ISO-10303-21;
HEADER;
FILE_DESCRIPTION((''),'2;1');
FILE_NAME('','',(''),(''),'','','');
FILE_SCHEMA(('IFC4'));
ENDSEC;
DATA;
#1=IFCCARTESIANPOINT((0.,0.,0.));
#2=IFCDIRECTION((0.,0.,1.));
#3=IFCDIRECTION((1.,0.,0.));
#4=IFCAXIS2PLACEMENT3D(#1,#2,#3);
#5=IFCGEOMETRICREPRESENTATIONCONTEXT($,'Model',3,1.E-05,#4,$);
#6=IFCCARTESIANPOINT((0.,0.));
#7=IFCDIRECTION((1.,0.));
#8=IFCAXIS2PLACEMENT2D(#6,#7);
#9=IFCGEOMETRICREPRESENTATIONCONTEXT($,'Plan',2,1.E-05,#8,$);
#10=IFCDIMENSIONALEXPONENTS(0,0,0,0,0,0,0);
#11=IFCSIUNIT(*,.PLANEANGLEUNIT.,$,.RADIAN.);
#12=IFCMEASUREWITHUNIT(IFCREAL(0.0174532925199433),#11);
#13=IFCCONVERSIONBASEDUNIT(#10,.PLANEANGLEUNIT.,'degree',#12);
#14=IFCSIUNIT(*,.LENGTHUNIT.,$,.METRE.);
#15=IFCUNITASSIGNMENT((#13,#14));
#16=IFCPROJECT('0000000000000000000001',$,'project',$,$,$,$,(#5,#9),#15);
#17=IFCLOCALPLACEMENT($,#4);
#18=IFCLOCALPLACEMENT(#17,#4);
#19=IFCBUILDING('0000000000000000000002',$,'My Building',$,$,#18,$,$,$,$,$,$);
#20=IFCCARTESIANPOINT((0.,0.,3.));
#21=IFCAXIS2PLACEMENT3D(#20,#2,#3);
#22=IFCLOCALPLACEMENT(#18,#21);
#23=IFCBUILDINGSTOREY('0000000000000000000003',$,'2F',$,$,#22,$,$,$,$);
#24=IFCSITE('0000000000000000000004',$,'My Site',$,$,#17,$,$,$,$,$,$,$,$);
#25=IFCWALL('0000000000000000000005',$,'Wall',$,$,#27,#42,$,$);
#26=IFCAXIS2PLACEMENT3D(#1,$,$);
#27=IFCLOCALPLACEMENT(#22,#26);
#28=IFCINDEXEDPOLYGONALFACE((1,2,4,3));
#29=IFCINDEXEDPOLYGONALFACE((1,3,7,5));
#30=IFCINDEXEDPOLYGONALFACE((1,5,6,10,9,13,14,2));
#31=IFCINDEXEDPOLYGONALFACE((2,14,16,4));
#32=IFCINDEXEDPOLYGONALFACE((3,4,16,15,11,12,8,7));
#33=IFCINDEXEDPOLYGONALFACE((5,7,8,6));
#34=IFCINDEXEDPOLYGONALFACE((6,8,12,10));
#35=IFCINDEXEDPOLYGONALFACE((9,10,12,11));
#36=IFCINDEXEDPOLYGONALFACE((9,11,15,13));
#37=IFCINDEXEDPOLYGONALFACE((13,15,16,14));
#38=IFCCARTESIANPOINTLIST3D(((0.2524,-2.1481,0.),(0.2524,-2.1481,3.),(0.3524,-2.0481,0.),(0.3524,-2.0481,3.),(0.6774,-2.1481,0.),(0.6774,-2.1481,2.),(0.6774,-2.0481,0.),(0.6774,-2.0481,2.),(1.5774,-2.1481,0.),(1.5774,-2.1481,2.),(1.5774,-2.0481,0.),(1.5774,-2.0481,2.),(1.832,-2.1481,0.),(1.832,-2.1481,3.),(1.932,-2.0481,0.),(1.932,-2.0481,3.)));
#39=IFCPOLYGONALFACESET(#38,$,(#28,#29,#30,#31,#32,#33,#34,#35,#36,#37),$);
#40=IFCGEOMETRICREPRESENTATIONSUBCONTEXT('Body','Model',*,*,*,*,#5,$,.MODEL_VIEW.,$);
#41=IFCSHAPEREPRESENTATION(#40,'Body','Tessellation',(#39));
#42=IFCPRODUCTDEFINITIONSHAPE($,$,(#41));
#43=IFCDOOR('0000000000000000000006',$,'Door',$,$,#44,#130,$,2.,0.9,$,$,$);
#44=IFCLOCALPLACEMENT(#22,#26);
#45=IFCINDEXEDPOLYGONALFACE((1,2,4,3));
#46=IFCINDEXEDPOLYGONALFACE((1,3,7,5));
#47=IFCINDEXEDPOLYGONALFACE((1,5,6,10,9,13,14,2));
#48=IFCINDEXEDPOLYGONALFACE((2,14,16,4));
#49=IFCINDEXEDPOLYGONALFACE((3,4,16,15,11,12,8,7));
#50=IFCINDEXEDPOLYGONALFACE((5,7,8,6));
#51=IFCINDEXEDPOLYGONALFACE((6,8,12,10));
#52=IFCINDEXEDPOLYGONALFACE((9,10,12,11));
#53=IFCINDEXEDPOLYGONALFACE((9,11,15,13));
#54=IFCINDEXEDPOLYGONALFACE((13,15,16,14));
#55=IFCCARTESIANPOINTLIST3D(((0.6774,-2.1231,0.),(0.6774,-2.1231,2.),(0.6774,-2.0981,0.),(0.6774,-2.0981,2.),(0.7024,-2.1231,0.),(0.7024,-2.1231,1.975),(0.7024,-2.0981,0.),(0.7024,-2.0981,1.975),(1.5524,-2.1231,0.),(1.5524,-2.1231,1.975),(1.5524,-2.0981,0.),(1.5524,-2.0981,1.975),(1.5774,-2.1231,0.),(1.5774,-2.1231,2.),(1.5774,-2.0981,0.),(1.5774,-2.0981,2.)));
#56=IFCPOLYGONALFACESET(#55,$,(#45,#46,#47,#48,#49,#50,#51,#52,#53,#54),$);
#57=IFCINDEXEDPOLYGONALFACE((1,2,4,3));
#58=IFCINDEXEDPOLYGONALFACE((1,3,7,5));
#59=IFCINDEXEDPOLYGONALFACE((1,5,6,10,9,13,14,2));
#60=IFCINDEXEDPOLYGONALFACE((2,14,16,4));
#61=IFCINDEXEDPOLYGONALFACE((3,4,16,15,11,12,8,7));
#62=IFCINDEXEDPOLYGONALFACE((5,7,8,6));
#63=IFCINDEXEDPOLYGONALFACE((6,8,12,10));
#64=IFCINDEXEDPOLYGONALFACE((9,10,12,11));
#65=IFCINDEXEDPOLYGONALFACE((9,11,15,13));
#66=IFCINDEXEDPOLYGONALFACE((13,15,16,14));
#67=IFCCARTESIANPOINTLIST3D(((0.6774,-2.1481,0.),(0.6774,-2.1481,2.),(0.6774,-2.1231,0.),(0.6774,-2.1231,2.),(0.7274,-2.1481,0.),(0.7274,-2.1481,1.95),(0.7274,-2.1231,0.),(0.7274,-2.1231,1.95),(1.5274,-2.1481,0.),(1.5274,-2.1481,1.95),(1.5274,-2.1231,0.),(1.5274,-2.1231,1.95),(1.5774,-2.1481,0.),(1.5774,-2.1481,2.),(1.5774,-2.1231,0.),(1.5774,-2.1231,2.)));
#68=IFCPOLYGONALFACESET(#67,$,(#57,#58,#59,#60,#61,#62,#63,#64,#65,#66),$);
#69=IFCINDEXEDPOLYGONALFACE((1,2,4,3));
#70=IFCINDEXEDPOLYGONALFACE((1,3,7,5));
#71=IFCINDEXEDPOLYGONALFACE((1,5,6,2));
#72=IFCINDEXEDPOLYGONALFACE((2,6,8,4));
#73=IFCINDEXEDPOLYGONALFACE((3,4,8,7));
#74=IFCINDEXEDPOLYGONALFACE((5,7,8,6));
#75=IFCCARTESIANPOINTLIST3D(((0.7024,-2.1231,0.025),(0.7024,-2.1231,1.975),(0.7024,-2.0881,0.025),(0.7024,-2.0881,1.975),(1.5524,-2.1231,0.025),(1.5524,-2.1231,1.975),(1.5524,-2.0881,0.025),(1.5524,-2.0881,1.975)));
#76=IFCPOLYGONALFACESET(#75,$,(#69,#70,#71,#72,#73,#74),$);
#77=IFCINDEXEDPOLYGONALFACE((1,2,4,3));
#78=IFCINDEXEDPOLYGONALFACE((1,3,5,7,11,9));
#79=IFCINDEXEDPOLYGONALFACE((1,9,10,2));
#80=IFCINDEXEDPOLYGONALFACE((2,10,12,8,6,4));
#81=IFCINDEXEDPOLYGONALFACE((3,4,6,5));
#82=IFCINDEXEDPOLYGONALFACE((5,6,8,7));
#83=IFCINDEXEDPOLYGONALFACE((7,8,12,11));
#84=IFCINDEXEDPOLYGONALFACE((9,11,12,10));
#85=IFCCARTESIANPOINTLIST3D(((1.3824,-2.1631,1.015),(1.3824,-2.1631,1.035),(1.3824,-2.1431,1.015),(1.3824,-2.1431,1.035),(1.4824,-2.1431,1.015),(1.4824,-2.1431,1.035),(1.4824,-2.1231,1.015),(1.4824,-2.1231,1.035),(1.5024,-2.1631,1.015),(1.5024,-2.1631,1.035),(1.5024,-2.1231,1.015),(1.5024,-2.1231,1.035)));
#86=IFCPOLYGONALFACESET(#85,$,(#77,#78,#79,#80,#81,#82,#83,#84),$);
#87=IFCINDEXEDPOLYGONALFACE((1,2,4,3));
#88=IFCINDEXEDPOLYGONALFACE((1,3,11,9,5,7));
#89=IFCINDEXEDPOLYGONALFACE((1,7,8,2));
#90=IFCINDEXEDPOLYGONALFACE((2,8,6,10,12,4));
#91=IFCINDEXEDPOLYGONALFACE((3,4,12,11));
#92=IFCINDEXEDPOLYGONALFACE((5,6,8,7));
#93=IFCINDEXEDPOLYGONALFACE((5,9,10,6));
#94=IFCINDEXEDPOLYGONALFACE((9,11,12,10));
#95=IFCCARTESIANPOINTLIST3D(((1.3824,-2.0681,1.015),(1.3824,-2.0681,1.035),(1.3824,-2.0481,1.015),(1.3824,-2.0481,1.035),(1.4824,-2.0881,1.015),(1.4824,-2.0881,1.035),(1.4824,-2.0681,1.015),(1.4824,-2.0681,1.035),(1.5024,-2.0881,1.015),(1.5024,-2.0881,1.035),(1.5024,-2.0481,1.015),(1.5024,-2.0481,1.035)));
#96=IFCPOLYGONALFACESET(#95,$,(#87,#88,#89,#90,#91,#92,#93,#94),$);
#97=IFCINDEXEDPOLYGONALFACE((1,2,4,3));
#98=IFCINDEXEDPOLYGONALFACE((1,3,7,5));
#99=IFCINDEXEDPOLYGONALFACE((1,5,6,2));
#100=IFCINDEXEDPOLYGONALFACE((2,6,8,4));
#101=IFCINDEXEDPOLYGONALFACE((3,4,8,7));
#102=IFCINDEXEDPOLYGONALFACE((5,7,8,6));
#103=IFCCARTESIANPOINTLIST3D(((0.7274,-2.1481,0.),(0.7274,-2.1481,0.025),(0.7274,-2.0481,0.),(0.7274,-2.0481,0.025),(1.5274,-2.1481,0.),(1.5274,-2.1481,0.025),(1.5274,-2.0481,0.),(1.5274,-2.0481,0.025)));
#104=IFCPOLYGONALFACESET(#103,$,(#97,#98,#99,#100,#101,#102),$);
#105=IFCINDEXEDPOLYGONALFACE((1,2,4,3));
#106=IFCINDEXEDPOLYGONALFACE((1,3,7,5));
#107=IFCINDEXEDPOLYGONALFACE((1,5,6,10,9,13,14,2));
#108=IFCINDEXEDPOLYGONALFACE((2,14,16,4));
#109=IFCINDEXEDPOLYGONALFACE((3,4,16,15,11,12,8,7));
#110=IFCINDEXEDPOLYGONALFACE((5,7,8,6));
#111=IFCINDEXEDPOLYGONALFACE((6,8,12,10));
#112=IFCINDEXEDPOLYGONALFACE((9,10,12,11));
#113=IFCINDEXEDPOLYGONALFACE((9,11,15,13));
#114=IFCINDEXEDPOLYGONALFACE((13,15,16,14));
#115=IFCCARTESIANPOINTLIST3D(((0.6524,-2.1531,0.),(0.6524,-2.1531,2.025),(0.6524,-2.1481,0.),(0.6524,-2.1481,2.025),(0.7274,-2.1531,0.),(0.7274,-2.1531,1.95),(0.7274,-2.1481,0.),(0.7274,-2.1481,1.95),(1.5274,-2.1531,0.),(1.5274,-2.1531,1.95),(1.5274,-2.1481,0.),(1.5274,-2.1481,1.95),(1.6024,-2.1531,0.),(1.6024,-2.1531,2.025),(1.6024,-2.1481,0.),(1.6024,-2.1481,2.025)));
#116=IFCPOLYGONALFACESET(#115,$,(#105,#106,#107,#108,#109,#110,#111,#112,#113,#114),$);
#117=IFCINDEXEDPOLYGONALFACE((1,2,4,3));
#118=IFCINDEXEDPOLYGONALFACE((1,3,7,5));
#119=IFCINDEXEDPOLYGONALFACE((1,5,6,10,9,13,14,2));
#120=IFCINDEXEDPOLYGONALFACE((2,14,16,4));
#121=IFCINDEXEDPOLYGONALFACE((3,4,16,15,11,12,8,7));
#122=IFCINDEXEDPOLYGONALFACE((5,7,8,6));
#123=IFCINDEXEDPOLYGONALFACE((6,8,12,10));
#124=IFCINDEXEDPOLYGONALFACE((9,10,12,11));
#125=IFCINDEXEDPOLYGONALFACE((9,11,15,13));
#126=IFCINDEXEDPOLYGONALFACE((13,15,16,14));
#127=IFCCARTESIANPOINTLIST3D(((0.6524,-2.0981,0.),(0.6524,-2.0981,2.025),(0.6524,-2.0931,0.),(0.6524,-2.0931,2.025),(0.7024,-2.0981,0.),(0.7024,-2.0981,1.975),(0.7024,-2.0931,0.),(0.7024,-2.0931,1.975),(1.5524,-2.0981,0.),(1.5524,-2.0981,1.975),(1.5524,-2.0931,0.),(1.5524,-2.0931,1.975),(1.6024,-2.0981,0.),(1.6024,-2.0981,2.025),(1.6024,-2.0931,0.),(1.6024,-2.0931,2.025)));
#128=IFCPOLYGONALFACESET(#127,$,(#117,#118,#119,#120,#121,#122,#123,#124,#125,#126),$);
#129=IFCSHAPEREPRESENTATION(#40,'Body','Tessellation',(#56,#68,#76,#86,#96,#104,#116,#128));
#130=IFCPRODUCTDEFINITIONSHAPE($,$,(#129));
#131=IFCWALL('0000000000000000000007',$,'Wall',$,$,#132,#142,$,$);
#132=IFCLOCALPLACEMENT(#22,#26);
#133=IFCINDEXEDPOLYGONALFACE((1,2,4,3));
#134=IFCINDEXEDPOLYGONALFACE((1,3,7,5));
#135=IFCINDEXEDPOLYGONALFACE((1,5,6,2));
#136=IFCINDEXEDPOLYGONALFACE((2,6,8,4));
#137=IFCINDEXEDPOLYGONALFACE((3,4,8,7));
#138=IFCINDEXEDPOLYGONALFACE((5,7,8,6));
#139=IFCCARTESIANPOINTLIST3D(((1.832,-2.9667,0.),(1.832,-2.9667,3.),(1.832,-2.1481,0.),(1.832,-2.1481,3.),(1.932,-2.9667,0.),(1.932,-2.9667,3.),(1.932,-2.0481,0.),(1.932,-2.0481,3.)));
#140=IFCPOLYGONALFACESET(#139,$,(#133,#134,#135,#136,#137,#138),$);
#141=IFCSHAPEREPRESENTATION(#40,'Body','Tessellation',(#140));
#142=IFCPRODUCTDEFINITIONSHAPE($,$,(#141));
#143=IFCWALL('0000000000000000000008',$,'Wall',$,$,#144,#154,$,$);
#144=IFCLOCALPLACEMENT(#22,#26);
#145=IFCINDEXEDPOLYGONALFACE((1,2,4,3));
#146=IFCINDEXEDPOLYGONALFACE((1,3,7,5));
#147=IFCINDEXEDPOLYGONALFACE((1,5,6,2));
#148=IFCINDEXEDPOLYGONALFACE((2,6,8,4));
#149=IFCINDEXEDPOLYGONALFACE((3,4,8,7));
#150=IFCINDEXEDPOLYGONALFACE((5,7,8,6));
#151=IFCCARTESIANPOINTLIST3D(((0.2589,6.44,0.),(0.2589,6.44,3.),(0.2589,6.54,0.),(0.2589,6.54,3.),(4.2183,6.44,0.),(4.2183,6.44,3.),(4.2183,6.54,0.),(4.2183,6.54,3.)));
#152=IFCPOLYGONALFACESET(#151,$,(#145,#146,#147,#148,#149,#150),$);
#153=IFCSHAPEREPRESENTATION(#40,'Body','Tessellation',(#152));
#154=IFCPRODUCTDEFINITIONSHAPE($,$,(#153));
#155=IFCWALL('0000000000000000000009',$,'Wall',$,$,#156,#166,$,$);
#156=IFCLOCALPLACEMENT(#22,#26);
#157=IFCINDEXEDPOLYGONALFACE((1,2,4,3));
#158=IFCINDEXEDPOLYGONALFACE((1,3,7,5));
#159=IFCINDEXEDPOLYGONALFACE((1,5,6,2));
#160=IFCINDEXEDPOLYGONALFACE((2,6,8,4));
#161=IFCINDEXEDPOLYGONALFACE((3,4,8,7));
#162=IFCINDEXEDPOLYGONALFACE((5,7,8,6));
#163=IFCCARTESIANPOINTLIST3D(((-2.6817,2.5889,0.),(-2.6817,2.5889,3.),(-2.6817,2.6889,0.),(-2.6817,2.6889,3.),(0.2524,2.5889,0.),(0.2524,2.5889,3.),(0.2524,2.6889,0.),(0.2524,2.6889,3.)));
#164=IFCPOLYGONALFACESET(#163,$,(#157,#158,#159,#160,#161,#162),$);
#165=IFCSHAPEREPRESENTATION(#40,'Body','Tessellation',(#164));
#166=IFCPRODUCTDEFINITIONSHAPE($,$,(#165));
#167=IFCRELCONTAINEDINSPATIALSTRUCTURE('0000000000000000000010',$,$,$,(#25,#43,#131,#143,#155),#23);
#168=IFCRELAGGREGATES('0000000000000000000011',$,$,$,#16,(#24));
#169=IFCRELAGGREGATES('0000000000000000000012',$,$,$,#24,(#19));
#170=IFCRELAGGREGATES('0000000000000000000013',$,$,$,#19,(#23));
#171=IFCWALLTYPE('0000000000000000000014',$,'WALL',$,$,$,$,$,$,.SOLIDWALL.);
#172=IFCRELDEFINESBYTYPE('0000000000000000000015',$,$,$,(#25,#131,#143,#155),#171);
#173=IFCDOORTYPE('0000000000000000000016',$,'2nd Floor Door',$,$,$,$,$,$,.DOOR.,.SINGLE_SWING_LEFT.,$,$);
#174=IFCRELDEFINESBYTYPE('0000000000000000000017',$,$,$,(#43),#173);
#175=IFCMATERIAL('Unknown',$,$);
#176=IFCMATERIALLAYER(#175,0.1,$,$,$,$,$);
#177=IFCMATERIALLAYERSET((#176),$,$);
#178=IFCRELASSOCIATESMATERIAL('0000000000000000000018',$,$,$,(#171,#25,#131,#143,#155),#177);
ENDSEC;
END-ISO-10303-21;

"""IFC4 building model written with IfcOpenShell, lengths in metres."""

from ifc_helpers import new_model, entity, si_unit, converted_unit, frame, origin_with_axes, origin_2d_with_axis, place, context, subcontext, project, spatial, line, indexed_curve, outline, extrude, shape, source, transform, mapped, material, layer, layer_set, layer_usage, type_object, type_shapes, element, fill, save


model = new_model("IFC4")

# Units and contexts
model_context = context("Model", 3, precision=1e-05, world=origin_with_axes())
plan_context = context("Plan", 2, precision=1e-05, world=origin_2d_with_axis())
body_context_1 = subcontext(model_context, "Body", "Model", "MODEL_VIEW")
body_context_2 = subcontext(plan_context, "Body", "Plan", "PLAN_VIEW")
ifc_project = project(units=[converted_unit("PLANEANGLEUNIT", "degree", entity("IfcReal", 0.0174532925199433), si_unit("PLANEANGLEUNIT", "RADIAN"), dimensions=[0, 0, 0, 0, 0, 0, 0]), si_unit("LENGTHUNIT", "METRE")], contexts=[model_context, plan_context])

# Site, building, storey
site_placement = place(None, origin_with_axes())
site = spatial("IfcSite", under=ifc_project, at=site_placement, Name="My Site")
building_placement = place(site_placement, origin_with_axes())
building = spatial("IfcBuilding", under=site, at=building_placement, Name="My Building")
storey_placement = place(building_placement, frame((0.0, 0.0, 3.0), z_axis=(0.0, 0.0, 1.0), x_axis=(1.0, 0.0, 0.0)))
storey = spatial("IfcBuildingStorey", under=building, at=storey_placement, Name="2F")

# Shared definitions
ifc_material = material(Name="Unknown")

# Shared definitions
ifc_layer_1 = layer(ifc_material, 0.1)
ifc_layer_set_1 = layer_set([ifc_layer_1])
wall_type = type_object("IfcWallType", Name="WALL", PredefinedType="SOLIDWALL", material=ifc_layer_set_1)

# Wall, opening, door
ifc_layer_usage_1 = layer_usage(ifc_layer_set_1, "AXIS2", "POSITIVE", 0.0)
wall_1_placement = place(storey_placement, frame((0.2524, -2.1481, 0.0), z_axis=(0.0, 0.0, 1.0), x_axis=(1.0, 0.0, 0.0)))
wall_1 = element("IfcWall", 1, at=wall_1_placement, inside=storey, type_object=wall_type, material=ifc_layer_usage_1, Name="Wall", context=body_context_1, shape_type="SweptSolid", body=[
    extrude(outline(indexed_curve([(0.0, 0.0), (0.1, 0.1), (1.6795, 0.1), (1.5795, 0.0)], segments=[line(1, 2, 3, 4, 1)])), origin_with_axes(), (0.0, 0.0, 1.0), 3.0),
])
shared_shape_1 = source(origin_with_axes(), body_context_1, "Body", "SweptSolid", [
    extrude(outline(indexed_curve([(0.0, 0.0), (0.9, 0.0), (0.9, 2.0), (0.0, 2.0)], segments=[line(1, 2, 3, 4, 1)])), frame((0.0, -0.6, 0.0), z_axis=(0.0, -1.0, 0.0), x_axis=(1.0, 0.0, 0.0)), (0.0, 0.0, -1.0), 1.2),
])
opening_1_placement = place(wall_1_placement, frame((0.425, 0.0, 0.0), z_axis=(0.0, 0.0, 1.0), x_axis=(1.0, 0.0, 0.0)))
opening_1 = element("IfcOpeningElement", 2, at=opening_1_placement, cuts=wall_1, PredefinedType="OPENING", context=body_context_1, shape_type="MappedRepresentation", body=[
    mapped(shared_shape_1, transform((0.0, 0.0, 0.0), x_axis=(1.0, 0.0, 0.0), y_axis=(0.0, 1.0, 0.0), z_axis=(0.0, 0.0, 1.0), scale=1.0)),
])
door_type = type_object("IfcDoorType", Name="2nd Floor Door", OperationType="SINGLE_SWING_LEFT", PredefinedType="DOOR")
shared_shape_2 = source(origin_with_axes(), body_context_1, "Body", "SweptSolid", [
    extrude(outline(indexed_curve([(0.0, 0.0), (0.0, 2.0), (0.9, 2.0), (0.9, 0.0), (0.875, 0.0), (0.875, 1.975), (0.025, 1.975), (0.025, 0.0)], segments=[line(1, 2, 3, 4, 5, 6, 7, 8, 1)])), frame((0.0, 0.025, 0.0), z_axis=(0.0, -1.0, 0.0), x_axis=(1.0, 0.0, 0.0)), (0.0, 0.0, -1.0), 0.025),
    extrude(outline(indexed_curve([(0.0, 0.0), (0.0, 2.0), (0.9, 2.0), (0.9, 0.0), (0.85, 0.0), (0.85, 1.95), (0.05, 1.95), (0.05, 0.0)], segments=[line(1, 2, 3, 4, 5, 6, 7, 8, 1)])), frame((0.0, 0.0, 0.0), z_axis=(0.0, -1.0, 0.0), x_axis=(1.0, 0.0, 0.0)), (0.0, 0.0, -1.0), 0.025),
    extrude(outline(indexed_curve([(0.0, 0.0), (0.85, 0.0), (0.85, 0.035), (0.0, 0.035)], segments=[line(1, 2, 3, 4, 1)])), frame((0.025, 0.025, 0.025), z_axis=(0.0, 0.0, 1.0), x_axis=(1.0, 0.0, 0.0)), (0.0, 0.0, 1.0), 1.95),
    extrude(outline(indexed_curve([(0.0, 0.0), (0.0, -0.04), (-0.12, -0.04), (-0.12, -0.02), (-0.02, -0.02), (-0.02, 0.0)], segments=[line(1, 2, 3, 4, 5, 6, 1)])), frame((0.825, 0.025, 1.015), z_axis=(0.0, 0.0, 1.0), x_axis=(1.0, 0.0, 0.0)), (0.0, 0.0, 1.0), 0.02),
    extrude(outline(indexed_curve([(0.0, 0.0), (0.0, 0.04), (-0.12, 0.04), (-0.12, 0.02), (-0.02, 0.02), (-0.02, 0.0)], segments=[line(1, 2, 3, 4, 5, 6, 1)])), frame((0.825, 0.06, 1.015), z_axis=(0.0, 0.0, 1.0), x_axis=(1.0, 0.0, 0.0)), (0.0, 0.0, 1.0), 0.02),
    extrude(outline(indexed_curve([(0.0, 0.0), (0.8, 0.0), (0.8, 0.1), (0.0, 0.1)], segments=[line(1, 2, 3, 4, 1)])), frame((0.05, 0.0, 0.0), z_axis=(0.0, 0.0, 1.0), x_axis=(1.0, 0.0, 0.0)), (0.0, 0.0, 1.0), 0.025),
    extrude(outline(indexed_curve([(0.0, 0.0), (0.0, 2.025), (0.95, 2.025), (0.95, 0.0), (0.875, 0.0), (0.875, 1.95), (0.075, 1.95), (0.075, 0.0)], segments=[line(1, 2, 3, 4, 5, 6, 7, 8, 1)])), frame((-0.025, -0.005, 0.0), z_axis=(0.0, -1.0, 0.0), x_axis=(1.0, 0.0, 0.0)), (0.0, 0.0, -1.0), 0.005),
    extrude(outline(indexed_curve([(0.0, 0.0), (0.0, 2.025), (0.95, 2.025), (0.95, 0.0), (0.9, 0.0), (0.9, 1.975), (0.05, 1.975), (0.05, 0.0)], segments=[line(1, 2, 3, 4, 5, 6, 7, 8, 1)])), frame((-0.025, 0.05, 0.0), z_axis=(0.0, -1.0, 0.0), x_axis=(1.0, 0.0, 0.0)), (0.0, 0.0, -1.0), 0.005),
])
shared_shape_3 = source(origin_with_axes(), body_context_2, "Body", "Curve2D", [
    entity("IfcIndexedPolyCurve", entity("IfcCartesianPointList2D", [[0.0, 0.0], [0.0, 0.05], [0.025, 0.05], [0.025, 0.025], [0.05, 0.025], [0.05, 0.0]]), [entity("IfcLineIndex", [1, 2, 3, 4, 5, 6, 1])]),
    entity("IfcIndexedPolyCurve", entity("IfcCartesianPointList2D", [[0.9, 0.0], [0.9, 0.05], [0.875, 0.05], [0.875, 0.025], [0.85, 0.025], [0.85, 0.0]]), [entity("IfcLineIndex", [1, 2, 3, 4, 5, 6, 1])]),
    entity("IfcTrimmedCurve", entity("IfcEllipse", entity("IfcAxis2Placement2D", entity("IfcCartesianPoint", [0.06, 0.05]), entity("IfcDirection", [1.0, 0.0])), 0.815, 0.85), [entity("IfcCartesianPoint", [0.875, 0.05])], [entity("IfcCartesianPoint", [0.06, 0.9])], True, "CARTESIAN"),
    entity("IfcIndexedPolyCurve", entity("IfcCartesianPointList2D", [[0.025, 0.05], [0.06, 0.05], [0.06, 0.9], [0.025, 0.9]]), [entity("IfcLineIndex", [1, 2, 3, 4, 1])]),
])
type_shapes(door_type, [shared_shape_2, shared_shape_3])
door_1_placement = place(opening_1_placement, frame((0.0, 0.0, 0.0), z_axis=(0.0, 0.0, 1.0), x_axis=(1.0, 0.0, 0.0)))
door_1 = element("IfcDoor", 3, at=door_1_placement, inside=storey, type_object=door_type, Name="Door", OverallHeight=2.0, OverallWidth=0.9, shapes=[
    shape(body_context_1, "Body", "MappedRepresentation", [mapped(shared_shape_2, transform((0.0, 0.0, 0.0), x_axis=(1.0, 0.0, 0.0), y_axis=(0.0, 1.0, 0.0), z_axis=(0.0, 0.0, 1.0), scale=1.0))]),
    shape(body_context_2, "Body", "MappedRepresentation", [mapped(shared_shape_3, transform((0.0, 0.0, 0.0), x_axis=(1.0, 0.0, 0.0), y_axis=(0.0, 1.0, 0.0), z_axis=(0.0, 0.0, 1.0), scale=1.0))]),
])
fill(opening_1, door_1)

# Walls
ifc_layer_usage_2 = layer_usage(ifc_layer_set_1, "AXIS2", "POSITIVE", 0.0)
wall_2_placement = place(storey_placement, frame((1.832, -2.1481, 0.0), z_axis=(0.0, 0.0, 1.0), x_axis=(0.0, -1.0, 0.0)))
element("IfcWall", 4, at=wall_2_placement, inside=storey, type_object=wall_type, material=ifc_layer_usage_2, Name="Wall", context=body_context_1, shape_type="SweptSolid", body=[
    extrude(outline(indexed_curve([(0.0, 0.0), (-0.1, 0.1), (0.8186, 0.1), (0.8186, 0.0)], segments=[line(1, 2, 3, 4, 1)])), origin_with_axes(), (0.0, 0.0, 1.0), 3.0),
])
ifc_layer_usage_3 = layer_usage(ifc_layer_set_1, "AXIS2", "POSITIVE", 0.0)
wall_3_placement = place(storey_placement, frame((4.2183, 6.54, 0.0), z_axis=(0.0, 0.0, 1.0), x_axis=(-1.0, 0.0, 0.0)))
element("IfcWall", 5, at=wall_3_placement, inside=storey, type_object=wall_type, material=ifc_layer_usage_3, Name="Wall", context=body_context_1, shape_type="SweptSolid", body=[
    extrude(outline(indexed_curve([(0.0, 0.0), (0.0, 0.1), (3.9595, 0.1), (3.9595, 0.0)], segments=[line(1, 2, 3, 4, 1)])), origin_with_axes(), (0.0, 0.0, 1.0), 3.0),
])
ifc_layer_usage_4 = layer_usage(ifc_layer_set_1, "AXIS2", "POSITIVE", 0.0)
wall_4_placement = place(storey_placement, frame((-2.6817, 2.5889, 0.0), z_axis=(0.0, 0.0, 1.0), x_axis=(1.0, 0.0, 0.0)))
element("IfcWall", 6, at=wall_4_placement, inside=storey, type_object=wall_type, material=ifc_layer_usage_4, Name="Wall", context=body_context_1, shape_type="SweptSolid", body=[
    extrude(outline(indexed_curve([(0.0, 0.0), (0.0, 0.1), (2.9341, 0.1), (2.9341, 0.0)], segments=[line(1, 2, 3, 4, 1)])), origin_with_axes(), (0.0, 0.0, 1.0), 3.0),
])

save(model, "model.ifc")
